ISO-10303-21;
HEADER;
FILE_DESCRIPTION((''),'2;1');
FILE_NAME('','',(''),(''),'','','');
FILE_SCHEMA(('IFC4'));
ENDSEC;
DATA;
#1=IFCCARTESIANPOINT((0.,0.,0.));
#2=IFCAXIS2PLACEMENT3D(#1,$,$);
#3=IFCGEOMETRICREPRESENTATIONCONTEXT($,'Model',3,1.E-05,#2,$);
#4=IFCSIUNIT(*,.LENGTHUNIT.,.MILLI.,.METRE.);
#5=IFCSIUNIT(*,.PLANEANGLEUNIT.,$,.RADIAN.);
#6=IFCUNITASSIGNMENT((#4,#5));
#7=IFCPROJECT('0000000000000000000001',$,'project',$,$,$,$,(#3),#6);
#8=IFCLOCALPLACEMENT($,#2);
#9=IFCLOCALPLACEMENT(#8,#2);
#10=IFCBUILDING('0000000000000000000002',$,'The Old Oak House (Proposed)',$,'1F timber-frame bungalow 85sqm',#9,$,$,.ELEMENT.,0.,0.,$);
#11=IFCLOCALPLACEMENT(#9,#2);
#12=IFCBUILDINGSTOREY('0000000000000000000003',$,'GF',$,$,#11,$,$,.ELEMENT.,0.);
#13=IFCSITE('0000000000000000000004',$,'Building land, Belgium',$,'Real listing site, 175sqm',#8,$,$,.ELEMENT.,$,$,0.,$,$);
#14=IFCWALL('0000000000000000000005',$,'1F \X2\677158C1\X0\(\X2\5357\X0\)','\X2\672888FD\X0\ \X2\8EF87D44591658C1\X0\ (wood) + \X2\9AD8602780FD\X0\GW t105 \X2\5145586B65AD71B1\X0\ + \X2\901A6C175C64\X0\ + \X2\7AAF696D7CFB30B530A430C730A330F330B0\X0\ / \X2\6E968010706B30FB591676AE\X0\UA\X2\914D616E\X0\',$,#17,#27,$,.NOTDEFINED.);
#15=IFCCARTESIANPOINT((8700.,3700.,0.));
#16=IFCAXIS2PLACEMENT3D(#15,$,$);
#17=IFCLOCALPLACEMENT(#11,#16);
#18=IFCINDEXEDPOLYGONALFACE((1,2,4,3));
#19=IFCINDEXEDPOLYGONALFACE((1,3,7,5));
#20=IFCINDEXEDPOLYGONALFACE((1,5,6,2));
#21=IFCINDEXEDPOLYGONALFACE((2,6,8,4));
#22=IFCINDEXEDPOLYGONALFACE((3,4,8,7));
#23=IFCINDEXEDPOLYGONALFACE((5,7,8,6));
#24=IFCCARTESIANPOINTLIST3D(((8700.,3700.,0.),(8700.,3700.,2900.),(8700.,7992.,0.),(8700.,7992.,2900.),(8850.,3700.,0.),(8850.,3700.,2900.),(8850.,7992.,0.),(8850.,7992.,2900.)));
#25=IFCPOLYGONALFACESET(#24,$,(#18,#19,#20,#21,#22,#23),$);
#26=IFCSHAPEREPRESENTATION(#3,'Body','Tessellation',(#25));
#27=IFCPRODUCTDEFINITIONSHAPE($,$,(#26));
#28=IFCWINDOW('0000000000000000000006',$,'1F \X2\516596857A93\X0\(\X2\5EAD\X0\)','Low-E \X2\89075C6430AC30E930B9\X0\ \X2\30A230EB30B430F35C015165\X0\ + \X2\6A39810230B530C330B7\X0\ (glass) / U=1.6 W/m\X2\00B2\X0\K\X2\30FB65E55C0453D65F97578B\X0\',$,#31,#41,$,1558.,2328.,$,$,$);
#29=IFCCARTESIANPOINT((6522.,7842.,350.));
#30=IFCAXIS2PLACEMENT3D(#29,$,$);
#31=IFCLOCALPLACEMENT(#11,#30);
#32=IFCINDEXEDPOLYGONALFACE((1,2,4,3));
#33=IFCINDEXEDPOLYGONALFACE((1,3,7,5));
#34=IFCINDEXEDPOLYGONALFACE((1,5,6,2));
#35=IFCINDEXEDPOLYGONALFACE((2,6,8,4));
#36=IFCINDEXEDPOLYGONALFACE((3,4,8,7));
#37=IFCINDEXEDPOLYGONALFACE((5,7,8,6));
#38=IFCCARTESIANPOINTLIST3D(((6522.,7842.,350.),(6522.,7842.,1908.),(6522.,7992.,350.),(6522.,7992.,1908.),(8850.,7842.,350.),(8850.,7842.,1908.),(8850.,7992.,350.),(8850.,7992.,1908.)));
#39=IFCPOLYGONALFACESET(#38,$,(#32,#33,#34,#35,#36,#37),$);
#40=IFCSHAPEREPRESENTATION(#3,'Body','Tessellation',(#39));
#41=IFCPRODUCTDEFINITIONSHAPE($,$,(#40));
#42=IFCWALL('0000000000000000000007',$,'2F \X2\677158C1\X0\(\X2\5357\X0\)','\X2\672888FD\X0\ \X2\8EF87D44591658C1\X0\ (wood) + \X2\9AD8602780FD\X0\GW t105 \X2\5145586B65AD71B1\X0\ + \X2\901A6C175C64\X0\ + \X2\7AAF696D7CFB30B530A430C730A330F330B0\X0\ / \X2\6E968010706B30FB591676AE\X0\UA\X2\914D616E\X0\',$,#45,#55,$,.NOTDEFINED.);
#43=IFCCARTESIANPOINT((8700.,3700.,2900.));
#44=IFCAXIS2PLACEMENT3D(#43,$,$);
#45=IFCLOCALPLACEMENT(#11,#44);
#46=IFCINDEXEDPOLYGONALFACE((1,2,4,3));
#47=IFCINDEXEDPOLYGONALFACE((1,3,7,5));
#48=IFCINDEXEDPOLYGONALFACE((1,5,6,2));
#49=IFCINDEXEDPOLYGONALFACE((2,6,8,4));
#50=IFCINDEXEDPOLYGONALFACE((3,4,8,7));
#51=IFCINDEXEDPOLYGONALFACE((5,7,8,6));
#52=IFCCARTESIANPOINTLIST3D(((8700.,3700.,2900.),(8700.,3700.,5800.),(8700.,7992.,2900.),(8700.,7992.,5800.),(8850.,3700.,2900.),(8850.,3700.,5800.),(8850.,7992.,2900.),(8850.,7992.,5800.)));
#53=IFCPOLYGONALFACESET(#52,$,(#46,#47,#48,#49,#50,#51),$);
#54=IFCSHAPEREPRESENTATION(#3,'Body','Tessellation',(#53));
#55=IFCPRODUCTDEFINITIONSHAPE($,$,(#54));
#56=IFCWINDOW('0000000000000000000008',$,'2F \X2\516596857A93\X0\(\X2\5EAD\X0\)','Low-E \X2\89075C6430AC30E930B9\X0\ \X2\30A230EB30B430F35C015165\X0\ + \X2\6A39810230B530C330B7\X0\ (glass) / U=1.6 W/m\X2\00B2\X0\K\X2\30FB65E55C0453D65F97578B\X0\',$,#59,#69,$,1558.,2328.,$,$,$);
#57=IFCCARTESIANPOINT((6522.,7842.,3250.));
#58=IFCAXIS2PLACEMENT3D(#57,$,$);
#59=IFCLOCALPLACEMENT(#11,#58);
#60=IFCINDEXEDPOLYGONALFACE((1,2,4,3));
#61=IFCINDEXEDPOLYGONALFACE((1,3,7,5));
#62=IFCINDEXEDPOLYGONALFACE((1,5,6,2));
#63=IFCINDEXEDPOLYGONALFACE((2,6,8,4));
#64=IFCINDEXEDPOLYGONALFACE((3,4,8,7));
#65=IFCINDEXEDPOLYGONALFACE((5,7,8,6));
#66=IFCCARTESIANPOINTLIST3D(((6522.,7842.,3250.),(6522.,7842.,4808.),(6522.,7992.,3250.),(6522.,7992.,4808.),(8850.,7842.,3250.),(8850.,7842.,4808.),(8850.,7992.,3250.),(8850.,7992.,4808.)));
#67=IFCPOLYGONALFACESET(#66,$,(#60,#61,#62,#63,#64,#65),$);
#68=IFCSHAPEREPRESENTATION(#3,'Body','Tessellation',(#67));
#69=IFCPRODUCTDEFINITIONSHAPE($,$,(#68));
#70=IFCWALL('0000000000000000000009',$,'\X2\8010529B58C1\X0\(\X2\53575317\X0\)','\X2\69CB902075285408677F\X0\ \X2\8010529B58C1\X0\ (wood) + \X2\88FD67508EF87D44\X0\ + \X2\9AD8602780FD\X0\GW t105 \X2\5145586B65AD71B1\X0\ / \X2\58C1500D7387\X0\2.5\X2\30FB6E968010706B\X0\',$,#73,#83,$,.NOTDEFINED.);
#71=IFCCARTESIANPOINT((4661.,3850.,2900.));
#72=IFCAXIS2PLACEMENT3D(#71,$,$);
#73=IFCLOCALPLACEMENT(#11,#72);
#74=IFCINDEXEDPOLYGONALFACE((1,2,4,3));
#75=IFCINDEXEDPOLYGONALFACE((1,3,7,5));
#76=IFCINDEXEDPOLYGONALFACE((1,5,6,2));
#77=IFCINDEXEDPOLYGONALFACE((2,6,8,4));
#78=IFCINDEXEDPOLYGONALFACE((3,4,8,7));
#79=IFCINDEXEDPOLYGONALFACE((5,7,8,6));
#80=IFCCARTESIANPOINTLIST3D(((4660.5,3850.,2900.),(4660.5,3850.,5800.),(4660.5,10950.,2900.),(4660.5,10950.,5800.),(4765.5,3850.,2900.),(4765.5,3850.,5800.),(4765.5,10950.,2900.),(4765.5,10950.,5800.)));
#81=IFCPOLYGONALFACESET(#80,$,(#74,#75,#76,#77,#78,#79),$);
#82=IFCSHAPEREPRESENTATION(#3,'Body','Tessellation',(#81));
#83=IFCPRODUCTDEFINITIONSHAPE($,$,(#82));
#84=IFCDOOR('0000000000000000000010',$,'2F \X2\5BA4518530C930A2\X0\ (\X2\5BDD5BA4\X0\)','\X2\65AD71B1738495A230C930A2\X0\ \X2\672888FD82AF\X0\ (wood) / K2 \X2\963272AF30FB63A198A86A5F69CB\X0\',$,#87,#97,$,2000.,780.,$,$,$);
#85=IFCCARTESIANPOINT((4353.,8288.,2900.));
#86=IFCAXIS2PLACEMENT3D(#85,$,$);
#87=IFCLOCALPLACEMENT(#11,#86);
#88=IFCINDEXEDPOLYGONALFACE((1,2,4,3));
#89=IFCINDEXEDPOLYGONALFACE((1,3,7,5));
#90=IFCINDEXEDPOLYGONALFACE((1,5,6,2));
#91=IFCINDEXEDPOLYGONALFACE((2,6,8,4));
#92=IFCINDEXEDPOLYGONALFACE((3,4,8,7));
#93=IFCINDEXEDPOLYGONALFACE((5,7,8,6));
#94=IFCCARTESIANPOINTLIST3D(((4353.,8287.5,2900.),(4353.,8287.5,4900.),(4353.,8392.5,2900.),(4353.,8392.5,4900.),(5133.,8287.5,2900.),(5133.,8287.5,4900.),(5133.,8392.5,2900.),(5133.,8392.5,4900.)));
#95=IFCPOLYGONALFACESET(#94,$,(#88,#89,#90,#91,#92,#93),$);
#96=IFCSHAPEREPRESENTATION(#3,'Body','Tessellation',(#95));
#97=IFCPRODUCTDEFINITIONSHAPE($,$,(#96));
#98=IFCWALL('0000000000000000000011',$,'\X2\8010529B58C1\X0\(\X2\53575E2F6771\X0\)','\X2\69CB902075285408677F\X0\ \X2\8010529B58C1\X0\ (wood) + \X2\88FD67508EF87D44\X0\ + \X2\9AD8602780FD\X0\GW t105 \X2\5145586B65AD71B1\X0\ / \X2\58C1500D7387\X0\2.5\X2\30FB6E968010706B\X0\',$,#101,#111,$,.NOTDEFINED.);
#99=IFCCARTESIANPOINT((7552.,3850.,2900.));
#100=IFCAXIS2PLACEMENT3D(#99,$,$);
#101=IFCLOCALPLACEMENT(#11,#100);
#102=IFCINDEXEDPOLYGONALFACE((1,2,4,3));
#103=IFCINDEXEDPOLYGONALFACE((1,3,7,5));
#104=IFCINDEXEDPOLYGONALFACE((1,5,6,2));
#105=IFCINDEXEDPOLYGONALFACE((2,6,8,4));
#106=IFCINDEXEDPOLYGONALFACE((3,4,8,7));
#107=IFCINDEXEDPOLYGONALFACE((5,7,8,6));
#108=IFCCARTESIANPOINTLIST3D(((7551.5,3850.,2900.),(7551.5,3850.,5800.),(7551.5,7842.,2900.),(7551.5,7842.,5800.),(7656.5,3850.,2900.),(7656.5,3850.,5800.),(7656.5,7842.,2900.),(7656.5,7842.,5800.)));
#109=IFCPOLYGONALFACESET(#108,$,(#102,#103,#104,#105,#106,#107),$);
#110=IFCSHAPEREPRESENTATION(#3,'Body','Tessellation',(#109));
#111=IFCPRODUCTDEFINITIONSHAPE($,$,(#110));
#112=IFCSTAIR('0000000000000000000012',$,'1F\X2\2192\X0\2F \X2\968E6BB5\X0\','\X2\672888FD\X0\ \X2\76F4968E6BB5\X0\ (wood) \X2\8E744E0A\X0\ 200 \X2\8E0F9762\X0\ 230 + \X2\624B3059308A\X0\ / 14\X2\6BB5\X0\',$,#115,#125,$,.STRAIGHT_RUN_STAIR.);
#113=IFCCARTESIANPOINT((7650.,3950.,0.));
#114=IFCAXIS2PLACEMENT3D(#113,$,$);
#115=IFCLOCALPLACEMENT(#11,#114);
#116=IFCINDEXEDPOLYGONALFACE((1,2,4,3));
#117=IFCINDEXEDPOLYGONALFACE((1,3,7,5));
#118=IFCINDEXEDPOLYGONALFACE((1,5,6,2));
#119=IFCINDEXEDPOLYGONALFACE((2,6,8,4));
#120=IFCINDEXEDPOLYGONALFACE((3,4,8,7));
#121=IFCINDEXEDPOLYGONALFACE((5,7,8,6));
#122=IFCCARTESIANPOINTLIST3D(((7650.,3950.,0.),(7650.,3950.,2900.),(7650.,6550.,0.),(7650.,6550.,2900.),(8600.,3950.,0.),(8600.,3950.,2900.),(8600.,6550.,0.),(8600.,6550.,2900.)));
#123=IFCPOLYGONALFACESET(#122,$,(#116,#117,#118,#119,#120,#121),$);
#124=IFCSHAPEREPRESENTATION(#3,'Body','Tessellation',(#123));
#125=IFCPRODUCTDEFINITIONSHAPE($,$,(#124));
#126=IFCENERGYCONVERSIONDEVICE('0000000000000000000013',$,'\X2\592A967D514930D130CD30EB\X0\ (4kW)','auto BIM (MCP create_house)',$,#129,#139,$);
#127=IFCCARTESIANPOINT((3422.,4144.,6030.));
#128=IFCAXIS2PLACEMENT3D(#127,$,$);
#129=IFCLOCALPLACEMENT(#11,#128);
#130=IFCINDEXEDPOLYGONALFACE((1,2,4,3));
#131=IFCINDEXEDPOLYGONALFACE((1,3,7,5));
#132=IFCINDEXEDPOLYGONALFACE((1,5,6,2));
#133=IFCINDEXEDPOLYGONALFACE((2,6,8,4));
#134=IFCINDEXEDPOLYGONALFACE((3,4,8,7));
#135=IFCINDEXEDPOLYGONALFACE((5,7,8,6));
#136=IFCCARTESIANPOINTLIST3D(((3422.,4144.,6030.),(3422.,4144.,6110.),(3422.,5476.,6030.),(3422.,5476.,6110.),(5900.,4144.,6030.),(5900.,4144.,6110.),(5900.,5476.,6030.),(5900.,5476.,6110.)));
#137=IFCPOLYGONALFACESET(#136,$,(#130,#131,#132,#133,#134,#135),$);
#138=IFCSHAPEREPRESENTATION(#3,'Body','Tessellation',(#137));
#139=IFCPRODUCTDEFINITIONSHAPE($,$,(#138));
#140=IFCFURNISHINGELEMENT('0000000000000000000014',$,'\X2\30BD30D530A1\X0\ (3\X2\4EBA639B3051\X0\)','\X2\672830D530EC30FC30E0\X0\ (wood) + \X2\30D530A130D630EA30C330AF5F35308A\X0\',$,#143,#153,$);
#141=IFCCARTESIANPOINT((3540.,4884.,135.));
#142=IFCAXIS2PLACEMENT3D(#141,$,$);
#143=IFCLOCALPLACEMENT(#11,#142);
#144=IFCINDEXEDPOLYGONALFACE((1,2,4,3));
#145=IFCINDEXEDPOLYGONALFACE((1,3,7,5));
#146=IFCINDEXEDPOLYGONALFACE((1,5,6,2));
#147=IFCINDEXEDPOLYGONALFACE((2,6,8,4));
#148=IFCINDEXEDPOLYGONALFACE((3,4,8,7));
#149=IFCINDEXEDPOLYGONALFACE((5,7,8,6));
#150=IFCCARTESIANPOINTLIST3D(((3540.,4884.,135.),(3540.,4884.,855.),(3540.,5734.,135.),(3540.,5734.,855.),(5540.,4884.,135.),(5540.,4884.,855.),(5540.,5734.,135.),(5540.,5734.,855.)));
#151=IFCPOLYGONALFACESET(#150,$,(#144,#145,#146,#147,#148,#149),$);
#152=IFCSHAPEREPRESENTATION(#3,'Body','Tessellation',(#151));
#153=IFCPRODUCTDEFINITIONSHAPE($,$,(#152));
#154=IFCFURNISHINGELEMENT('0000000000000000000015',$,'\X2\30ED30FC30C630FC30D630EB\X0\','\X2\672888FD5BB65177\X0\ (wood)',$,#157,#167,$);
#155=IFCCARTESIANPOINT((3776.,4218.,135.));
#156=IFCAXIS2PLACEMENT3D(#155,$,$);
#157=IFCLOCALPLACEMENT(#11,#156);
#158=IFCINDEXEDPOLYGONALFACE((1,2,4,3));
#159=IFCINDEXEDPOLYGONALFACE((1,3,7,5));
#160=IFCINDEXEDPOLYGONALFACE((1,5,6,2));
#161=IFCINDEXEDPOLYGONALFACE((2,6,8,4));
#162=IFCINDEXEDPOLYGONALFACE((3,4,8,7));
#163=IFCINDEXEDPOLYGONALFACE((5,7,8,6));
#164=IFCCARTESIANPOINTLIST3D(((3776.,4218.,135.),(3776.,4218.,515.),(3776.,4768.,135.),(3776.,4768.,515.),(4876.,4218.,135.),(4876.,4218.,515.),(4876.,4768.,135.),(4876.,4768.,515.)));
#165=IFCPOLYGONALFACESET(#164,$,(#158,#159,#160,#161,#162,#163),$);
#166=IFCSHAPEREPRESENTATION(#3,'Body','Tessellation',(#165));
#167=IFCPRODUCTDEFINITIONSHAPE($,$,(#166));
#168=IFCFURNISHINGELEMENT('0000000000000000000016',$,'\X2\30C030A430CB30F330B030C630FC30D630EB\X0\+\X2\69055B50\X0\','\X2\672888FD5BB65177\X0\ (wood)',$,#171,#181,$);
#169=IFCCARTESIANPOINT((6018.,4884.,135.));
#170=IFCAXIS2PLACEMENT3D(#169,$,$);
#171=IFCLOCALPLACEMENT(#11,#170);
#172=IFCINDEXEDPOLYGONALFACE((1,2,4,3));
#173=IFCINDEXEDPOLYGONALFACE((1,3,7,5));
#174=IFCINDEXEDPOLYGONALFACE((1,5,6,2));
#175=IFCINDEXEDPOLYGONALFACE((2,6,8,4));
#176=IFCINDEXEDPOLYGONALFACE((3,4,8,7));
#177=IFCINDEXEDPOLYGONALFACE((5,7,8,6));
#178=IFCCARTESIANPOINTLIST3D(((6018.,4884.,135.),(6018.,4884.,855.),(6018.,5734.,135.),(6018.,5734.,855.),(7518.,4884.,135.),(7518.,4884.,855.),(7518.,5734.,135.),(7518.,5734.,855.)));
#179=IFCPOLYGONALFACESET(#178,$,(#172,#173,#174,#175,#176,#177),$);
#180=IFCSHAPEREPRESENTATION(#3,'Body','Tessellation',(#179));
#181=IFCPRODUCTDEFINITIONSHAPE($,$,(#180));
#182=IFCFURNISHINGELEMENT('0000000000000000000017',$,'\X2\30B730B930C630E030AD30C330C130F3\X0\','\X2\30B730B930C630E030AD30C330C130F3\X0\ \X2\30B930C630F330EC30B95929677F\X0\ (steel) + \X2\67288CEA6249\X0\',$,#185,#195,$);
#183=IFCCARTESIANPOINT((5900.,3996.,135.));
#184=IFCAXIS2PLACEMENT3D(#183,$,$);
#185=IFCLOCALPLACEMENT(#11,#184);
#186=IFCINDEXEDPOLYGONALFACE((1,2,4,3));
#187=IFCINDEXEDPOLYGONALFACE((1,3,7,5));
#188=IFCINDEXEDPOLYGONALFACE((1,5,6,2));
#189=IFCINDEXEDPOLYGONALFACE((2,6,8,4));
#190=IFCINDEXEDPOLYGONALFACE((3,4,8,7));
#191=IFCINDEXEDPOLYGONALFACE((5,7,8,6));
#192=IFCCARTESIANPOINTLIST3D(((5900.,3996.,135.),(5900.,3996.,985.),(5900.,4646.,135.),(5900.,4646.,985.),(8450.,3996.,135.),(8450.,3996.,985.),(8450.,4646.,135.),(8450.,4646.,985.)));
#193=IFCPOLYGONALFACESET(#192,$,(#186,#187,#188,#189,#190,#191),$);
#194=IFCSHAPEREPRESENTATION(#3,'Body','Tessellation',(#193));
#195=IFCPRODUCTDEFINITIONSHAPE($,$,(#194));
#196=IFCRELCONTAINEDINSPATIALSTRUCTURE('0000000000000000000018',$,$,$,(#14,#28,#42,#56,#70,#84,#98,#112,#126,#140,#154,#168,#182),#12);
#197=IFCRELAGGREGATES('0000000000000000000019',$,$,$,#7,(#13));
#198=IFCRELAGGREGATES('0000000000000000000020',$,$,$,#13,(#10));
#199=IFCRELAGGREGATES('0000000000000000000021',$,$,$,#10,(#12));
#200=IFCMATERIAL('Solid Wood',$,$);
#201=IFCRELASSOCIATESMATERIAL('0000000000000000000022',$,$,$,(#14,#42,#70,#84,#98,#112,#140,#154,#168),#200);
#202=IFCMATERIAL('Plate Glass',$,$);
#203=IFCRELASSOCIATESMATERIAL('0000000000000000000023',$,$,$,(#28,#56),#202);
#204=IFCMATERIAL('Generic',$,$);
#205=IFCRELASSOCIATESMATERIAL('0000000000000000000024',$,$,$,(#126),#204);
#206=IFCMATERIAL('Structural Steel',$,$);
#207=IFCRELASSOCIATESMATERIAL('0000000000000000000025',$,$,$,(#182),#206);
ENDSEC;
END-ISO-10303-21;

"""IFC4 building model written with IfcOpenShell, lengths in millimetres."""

from ifc_helpers import new_model, si_unit, frame, frame_2d, origin, place, context, project, spatial, rectangle, extrude, material, element, fill, save


model = new_model("IFC4")

# Units and contexts
model_context = context("Model", 3, precision=1e-05, world=origin())
ifc_project = project(units=[si_unit("LENGTHUNIT", "METRE", prefix="MILLI"), si_unit("PLANEANGLEUNIT", "RADIAN")], contexts=[model_context])

# Site, building, storey
site_placement = place(None, origin())
site = spatial("IfcSite", under=ifc_project, at=site_placement, Name="Building land, Belgium", ObjectType="Real listing site, 175sqm", CompositionType="ELEMENT", RefElevation=0.0)
building_placement = place(site_placement, origin())
building = spatial("IfcBuilding", under=site, at=building_placement, Name="The Old Oak House (Proposed)", ObjectType="1F timber-frame bungalow 85sqm", CompositionType="ELEMENT", ElevationOfRefHeight=0.0, ElevationOfTerrain=0.0)
storey_placement = place(building_placement, origin())
storey = spatial("IfcBuildingStorey", under=building, at=storey_placement, Name="GF", CompositionType="ELEMENT", Elevation=0.0)

# Wall, opening, window
ifc_material_1 = material(Name="Solid Wood")
wall_1_placement = place(storey_placement, frame((8700.0, 3700.0, 0.0)))
wall_1 = element("IfcWall", 1, at=wall_1_placement, inside=storey, material=ifc_material_1, Name="1F 東壁(南)", Description="木製 軸組外壁 (wood) + 高性能GW t105 充填断熱 + 通気層 + 窯業系サイディング / 準耐火・外皮UA配慮", PredefinedType="NOTDEFINED", context=model_context, shape_type="SweptSolid", body=[
    extrude(rectangle(XDim=150.0, YDim=4292.0, at=frame_2d((75.0, 2146.0))), frame((8700.0, 3700.0, 0.0)), (0.0, 0.0, 1.0), 2900.0),
])
opening_1_placement = place(storey_placement, frame((6522.0, 7842.0, 350.0)))
opening_1 = element("IfcOpeningElement", 2, at=opening_1_placement, cuts=wall_1, PredefinedType="NOTDEFINED", context=model_context, shape_type="SweptSolid", body=[
    extrude(rectangle(XDim=2328.0, YDim=150.0, at=frame_2d((1164.0, 75.0))), frame((6522.0, 7842.0, 350.0)), (0.0, 0.0, 1.0), 1558.0),
])
ifc_material_2 = material(Name="Plate Glass")
window_1_placement = place(storey_placement, frame((6522.0, 7842.0, 350.0)))
window_1 = element("IfcWindow", 3, at=window_1_placement, inside=storey, material=ifc_material_2, Name="1F 入隅窓(庭)", Description="Low-E 複層ガラス アルゴン封入 + 樹脂サッシ (glass) / U=1.6 W/m²K・日射取得型", OverallHeight=1558.0, OverallWidth=2328.0, context=model_context, shape_type="SweptSolid", body=[
    extrude(rectangle(XDim=2328.0, YDim=150.0, at=frame_2d((1164.0, 75.0))), frame((6522.0, 7842.0, 350.0)), (0.0, 0.0, 1.0), 1558.0),
])
fill(opening_1, window_1)

# Wall, opening, window
wall_2_placement = place(storey_placement, frame((8700.0, 3700.0, 2900.0)))
wall_2 = element("IfcWall", 4, at=wall_2_placement, inside=storey, material=ifc_material_1, Name="2F 東壁(南)", Description="木製 軸組外壁 (wood) + 高性能GW t105 充填断熱 + 通気層 + 窯業系サイディング / 準耐火・外皮UA配慮", PredefinedType="NOTDEFINED", context=model_context, shape_type="SweptSolid", body=[
    extrude(rectangle(XDim=150.0, YDim=4292.0, at=frame_2d((75.0, 2146.0))), frame((8700.0, 3700.0, 2900.0)), (0.0, 0.0, 1.0), 2900.0),
])
opening_2_placement = place(storey_placement, frame((6522.0, 7842.0, 3250.0)))
opening_2 = element("IfcOpeningElement", 5, at=opening_2_placement, cuts=wall_2, PredefinedType="NOTDEFINED", context=model_context, shape_type="SweptSolid", body=[
    extrude(rectangle(XDim=2328.0, YDim=150.0, at=frame_2d((1164.0, 75.0))), frame((6522.0, 7842.0, 3250.0)), (0.0, 0.0, 1.0), 1558.0),
])
window_2_placement = place(storey_placement, frame((6522.0, 7842.0, 3250.0)))
window_2 = element("IfcWindow", 6, at=window_2_placement, inside=storey, material=ifc_material_2, Name="2F 入隅窓(庭)", Description="Low-E 複層ガラス アルゴン封入 + 樹脂サッシ (glass) / U=1.6 W/m²K・日射取得型", OverallHeight=1558.0, OverallWidth=2328.0, context=model_context, shape_type="SweptSolid", body=[
    extrude(rectangle(XDim=2328.0, YDim=150.0, at=frame_2d((1164.0, 75.0))), frame((6522.0, 7842.0, 3250.0)), (0.0, 0.0, 1.0), 1558.0),
])
fill(opening_2, window_2)

# Wall, opening, door
wall_3_placement = place(storey_placement, frame((4661.0, 3850.0, 2900.0)))
wall_3 = element("IfcWall", 7, at=wall_3_placement, inside=storey, material=ifc_material_1, Name="耐力壁(南北)", Description="構造用合板 耐力壁 (wood) + 製材軸組 + 高性能GW t105 充填断熱 / 壁倍率2.5・準耐火", PredefinedType="NOTDEFINED", context=model_context, shape_type="SweptSolid", body=[
    extrude(rectangle(XDim=105.0, YDim=7100.0, at=frame_2d((52.0, 3550.0))), frame((4661.0, 3850.0, 2900.0)), (0.0, 0.0, 1.0), 2900.0),
])
opening_3_placement = place(storey_placement, frame((4353.0, 8288.0, 2900.0)))
opening_3 = element("IfcOpeningElement", 8, at=opening_3_placement, cuts=wall_3, PredefinedType="NOTDEFINED", context=model_context, shape_type="SweptSolid", body=[
    extrude(rectangle(XDim=780.0, YDim=105.0, at=frame_2d((390.0, 52.0))), frame((4353.0, 8288.0, 2900.0)), (0.0, 0.0, 1.0), 2000.0),
])
door_1_placement = place(storey_placement, frame((4353.0, 8288.0, 2900.0)))
door_1 = element("IfcDoor", 9, at=door_1_placement, inside=storey, material=ifc_material_1, Name="2F 室内ドア (寝室)", Description="断熱玄関ドア 木製芯 (wood) / K2 防犯・採風機構", OverallHeight=2000.0, OverallWidth=780.0, context=model_context, shape_type="SweptSolid", body=[
    extrude(rectangle(XDim=780.0, YDim=105.0, at=frame_2d((390.0, 52.0))), frame((4353.0, 8288.0, 2900.0)), (0.0, 0.0, 1.0), 2000.0),
])
fill(opening_3, door_1)

# Wall
wall_4_placement = place(storey_placement, frame((7552.0, 3850.0, 2900.0)))
element("IfcWall", 10, at=wall_4_placement, inside=storey, material=ifc_material_1, Name="耐力壁(南帯東)", Description="構造用合板 耐力壁 (wood) + 製材軸組 + 高性能GW t105 充填断熱 / 壁倍率2.5・準耐火", PredefinedType="NOTDEFINED", context=model_context, shape_type="SweptSolid", body=[
    extrude(rectangle(XDim=105.0, YDim=3992.0, at=frame_2d((52.0, 1996.0))), frame((7552.0, 3850.0, 2900.0)), (0.0, 0.0, 1.0), 2900.0),
])

# Stair
stair_placement = place(storey_placement, frame((7650.0, 3950.0, 0.0)))
element("IfcStair", 11, at=stair_placement, inside=storey, material=ifc_material_1, Name="1F→2F 階段", Description="木製 直階段 (wood) 蹴上 200 踏面 230 + 手すり / 14段", PredefinedType="STRAIGHT_RUN_STAIR", context=model_context, shape_type="SweptSolid", body=[
    extrude(rectangle(XDim=950.0, YDim=2600.0, at=frame_2d((475.0, 1300.0))), frame((7650.0, 3950.0, 0.0)), (0.0, 0.0, 1.0), 2900.0),
])

# Energy conversion device
ifc_material_3 = material(Name="Generic")
energy_conversion_device_placement = place(storey_placement, frame((3422.0, 4144.0, 6030.0)))
element("IfcEnergyConversionDevice", 12, at=energy_conversion_device_placement, inside=storey, material=ifc_material_3, Name="太陽光パネル (4kW)", Description="auto BIM (MCP create_house)", context=model_context, shape_type="SweptSolid", body=[
    extrude(rectangle(XDim=2478.0, YDim=1332.0, at=frame_2d((1239.0, 666.0))), frame((3422.0, 4144.0, 6030.0)), (0.0, 0.0, 1.0), 80.0),
])

# Furnishing elements
furnishing_1_placement = place(storey_placement, frame((3540.0, 4884.0, 135.0)))
element("IfcFurnishingElement", 13, at=furnishing_1_placement, inside=storey, material=ifc_material_1, Name="ソファ (3人掛け)", Description="木フレーム (wood) + ファブリック張り", context=model_context, shape_type="SweptSolid", body=[
    extrude(rectangle(XDim=2000.0, YDim=850.0, at=frame_2d((1000.0, 425.0))), frame((3540.0, 4884.0, 135.0)), (0.0, 0.0, 1.0), 720.0),
])
furnishing_2_placement = place(storey_placement, frame((3776.0, 4218.0, 135.0)))
element("IfcFurnishingElement", 14, at=furnishing_2_placement, inside=storey, material=ifc_material_1, Name="ローテーブル", Description="木製家具 (wood)", context=model_context, shape_type="SweptSolid", body=[
    extrude(rectangle(XDim=1100.0, YDim=550.0, at=frame_2d((550.0, 275.0))), frame((3776.0, 4218.0, 135.0)), (0.0, 0.0, 1.0), 380.0),
])
furnishing_3_placement = place(storey_placement, frame((6018.0, 4884.0, 135.0)))
element("IfcFurnishingElement", 15, at=furnishing_3_placement, inside=storey, material=ifc_material_1, Name="ダイニングテーブル+椅子", Description="木製家具 (wood)", context=model_context, shape_type="SweptSolid", body=[
    extrude(rectangle(XDim=1500.0, YDim=850.0, at=frame_2d((750.0, 425.0))), frame((6018.0, 4884.0, 135.0)), (0.0, 0.0, 1.0), 720.0),
])
ifc_material_4 = material(Name="Structural Steel")
furnishing_4_placement = place(storey_placement, frame((5900.0, 3996.0, 135.0)))
element("IfcFurnishingElement", 16, at=furnishing_4_placement, inside=storey, material=ifc_material_4, Name="システムキッチン", Description="システムキッチン ステンレス天板 (steel) + 木質扉", context=model_context, shape_type="SweptSolid", body=[
    extrude(rectangle(XDim=2550.0, YDim=650.0, at=frame_2d((1275.0, 325.0))), frame((5900.0, 3996.0, 135.0)), (0.0, 0.0, 1.0), 850.0),
])

save(model, "model.ifc")
